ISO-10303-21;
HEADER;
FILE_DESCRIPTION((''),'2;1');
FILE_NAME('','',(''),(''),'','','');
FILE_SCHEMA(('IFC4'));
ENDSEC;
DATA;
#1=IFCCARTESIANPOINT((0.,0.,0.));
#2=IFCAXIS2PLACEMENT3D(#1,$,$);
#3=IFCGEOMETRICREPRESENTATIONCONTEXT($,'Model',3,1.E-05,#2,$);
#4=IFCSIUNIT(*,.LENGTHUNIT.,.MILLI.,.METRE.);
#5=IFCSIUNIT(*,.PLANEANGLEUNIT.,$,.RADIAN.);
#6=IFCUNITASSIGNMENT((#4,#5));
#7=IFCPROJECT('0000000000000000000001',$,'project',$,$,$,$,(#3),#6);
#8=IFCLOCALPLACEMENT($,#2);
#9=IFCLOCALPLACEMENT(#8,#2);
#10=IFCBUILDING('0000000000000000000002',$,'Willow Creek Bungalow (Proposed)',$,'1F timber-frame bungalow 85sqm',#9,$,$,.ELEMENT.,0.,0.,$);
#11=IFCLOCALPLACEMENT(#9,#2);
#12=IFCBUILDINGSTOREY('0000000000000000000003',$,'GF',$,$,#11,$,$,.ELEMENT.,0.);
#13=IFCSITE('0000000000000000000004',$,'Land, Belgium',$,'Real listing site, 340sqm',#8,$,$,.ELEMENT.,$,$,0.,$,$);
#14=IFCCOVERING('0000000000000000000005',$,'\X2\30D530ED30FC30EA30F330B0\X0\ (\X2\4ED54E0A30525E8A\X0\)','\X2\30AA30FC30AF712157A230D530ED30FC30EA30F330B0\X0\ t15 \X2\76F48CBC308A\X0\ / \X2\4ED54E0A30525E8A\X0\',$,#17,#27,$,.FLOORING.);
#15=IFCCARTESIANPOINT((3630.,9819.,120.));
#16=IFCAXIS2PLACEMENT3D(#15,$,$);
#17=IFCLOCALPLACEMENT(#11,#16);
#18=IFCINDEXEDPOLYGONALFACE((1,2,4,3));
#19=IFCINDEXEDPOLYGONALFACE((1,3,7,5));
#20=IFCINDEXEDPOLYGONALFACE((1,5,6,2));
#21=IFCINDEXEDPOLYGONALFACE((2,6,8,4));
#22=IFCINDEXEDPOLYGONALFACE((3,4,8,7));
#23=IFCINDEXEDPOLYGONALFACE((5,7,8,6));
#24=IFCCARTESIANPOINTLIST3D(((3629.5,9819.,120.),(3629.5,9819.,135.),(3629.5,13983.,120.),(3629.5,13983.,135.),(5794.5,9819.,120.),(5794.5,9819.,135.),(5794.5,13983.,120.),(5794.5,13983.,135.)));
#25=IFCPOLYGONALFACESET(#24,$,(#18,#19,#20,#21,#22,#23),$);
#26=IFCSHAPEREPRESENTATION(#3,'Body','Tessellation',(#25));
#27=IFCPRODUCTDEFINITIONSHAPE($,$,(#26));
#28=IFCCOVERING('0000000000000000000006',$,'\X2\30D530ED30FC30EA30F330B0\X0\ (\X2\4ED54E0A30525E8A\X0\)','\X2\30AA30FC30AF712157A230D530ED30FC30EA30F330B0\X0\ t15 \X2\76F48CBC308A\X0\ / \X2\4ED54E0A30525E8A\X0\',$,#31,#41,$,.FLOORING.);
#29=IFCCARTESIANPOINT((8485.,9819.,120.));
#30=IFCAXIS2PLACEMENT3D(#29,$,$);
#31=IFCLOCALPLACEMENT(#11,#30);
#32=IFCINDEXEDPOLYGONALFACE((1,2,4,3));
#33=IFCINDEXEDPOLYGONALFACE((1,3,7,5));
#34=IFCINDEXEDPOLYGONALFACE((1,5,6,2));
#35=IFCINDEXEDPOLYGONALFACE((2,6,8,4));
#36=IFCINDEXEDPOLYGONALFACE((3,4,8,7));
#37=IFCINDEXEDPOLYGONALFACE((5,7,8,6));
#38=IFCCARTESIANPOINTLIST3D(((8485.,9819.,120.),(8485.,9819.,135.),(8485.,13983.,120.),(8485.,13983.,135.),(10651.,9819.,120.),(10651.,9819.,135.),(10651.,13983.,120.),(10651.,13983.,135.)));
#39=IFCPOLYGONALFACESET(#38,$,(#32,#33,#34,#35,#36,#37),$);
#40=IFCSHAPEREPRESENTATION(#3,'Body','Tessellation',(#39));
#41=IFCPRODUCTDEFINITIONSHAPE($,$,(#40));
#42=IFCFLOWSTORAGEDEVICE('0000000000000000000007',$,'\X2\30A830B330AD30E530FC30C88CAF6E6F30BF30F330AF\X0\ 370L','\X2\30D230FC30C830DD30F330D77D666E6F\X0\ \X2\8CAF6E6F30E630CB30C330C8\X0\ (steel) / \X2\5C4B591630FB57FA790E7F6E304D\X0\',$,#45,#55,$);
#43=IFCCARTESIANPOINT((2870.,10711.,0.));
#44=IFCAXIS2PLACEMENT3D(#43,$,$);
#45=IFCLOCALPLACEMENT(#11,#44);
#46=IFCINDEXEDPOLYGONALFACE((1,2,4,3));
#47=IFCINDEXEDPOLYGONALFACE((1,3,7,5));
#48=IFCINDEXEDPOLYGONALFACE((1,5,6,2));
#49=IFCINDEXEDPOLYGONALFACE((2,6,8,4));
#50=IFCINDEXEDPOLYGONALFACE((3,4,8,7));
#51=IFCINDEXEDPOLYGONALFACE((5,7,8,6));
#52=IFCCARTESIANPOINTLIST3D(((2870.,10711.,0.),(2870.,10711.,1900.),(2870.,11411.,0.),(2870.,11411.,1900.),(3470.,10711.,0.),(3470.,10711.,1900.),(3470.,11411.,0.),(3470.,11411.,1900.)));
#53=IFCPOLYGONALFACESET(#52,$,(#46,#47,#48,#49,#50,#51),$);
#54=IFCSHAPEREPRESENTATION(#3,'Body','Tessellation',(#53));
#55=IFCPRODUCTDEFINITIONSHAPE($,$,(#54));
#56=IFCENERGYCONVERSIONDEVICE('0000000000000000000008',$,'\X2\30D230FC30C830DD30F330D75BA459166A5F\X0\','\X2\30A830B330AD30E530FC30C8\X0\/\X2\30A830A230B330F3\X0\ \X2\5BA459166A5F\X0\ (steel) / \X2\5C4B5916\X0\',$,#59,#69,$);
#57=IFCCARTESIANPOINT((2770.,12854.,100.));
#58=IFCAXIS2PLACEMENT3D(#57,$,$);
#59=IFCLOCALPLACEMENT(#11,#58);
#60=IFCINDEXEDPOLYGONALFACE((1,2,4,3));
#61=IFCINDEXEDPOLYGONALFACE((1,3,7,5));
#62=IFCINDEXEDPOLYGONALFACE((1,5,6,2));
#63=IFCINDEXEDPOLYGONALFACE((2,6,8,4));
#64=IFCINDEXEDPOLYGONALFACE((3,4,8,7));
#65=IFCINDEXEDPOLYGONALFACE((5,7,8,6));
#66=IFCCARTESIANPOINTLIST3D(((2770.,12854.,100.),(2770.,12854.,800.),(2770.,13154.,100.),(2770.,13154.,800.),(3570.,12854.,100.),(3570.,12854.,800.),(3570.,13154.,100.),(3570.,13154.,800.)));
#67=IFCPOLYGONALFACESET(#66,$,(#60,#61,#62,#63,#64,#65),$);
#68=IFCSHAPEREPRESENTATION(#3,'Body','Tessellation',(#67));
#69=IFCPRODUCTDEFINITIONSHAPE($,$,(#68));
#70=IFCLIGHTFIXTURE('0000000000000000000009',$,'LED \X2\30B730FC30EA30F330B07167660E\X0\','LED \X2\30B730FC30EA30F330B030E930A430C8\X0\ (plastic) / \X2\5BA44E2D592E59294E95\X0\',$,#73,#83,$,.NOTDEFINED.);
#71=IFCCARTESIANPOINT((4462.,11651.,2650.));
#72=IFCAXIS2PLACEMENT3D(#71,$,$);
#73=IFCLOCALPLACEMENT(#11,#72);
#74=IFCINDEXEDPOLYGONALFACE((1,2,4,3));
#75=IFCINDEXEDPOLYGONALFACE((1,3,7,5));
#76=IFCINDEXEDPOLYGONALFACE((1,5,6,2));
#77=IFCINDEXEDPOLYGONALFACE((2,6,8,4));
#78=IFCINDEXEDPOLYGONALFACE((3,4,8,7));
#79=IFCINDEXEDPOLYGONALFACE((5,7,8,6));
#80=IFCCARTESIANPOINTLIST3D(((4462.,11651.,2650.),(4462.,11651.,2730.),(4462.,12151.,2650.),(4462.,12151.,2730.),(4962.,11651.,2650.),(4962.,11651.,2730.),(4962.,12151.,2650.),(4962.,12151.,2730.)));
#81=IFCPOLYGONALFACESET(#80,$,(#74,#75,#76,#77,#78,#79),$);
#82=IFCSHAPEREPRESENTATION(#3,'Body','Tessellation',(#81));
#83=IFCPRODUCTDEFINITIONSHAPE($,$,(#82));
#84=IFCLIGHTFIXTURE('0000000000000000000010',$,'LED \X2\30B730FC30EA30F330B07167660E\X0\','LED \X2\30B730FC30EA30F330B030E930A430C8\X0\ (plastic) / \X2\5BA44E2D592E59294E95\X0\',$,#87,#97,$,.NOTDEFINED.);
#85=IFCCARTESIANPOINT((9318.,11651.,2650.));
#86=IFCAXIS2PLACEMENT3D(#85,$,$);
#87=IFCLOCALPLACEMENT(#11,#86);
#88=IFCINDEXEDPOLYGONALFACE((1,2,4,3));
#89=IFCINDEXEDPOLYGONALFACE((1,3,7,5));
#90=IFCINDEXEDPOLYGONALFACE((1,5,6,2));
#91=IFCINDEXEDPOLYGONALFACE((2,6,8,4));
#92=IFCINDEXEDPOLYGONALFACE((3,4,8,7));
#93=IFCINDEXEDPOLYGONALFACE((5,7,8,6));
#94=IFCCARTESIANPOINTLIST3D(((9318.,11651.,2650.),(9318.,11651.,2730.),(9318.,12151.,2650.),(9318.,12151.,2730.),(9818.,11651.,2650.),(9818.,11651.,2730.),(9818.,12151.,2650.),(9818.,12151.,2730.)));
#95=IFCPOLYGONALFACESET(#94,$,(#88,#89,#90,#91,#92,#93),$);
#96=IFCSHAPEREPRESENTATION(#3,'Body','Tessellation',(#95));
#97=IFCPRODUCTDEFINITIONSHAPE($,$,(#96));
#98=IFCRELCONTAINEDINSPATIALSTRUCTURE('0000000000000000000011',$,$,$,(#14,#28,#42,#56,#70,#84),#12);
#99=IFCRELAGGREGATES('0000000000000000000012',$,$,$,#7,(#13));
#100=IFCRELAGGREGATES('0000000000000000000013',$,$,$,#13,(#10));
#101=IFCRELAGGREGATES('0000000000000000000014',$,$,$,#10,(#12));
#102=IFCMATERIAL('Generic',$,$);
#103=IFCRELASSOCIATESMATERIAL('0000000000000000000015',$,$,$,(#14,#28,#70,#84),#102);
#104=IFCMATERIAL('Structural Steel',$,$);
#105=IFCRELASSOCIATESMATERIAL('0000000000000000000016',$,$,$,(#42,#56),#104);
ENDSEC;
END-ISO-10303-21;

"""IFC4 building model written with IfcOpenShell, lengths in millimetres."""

from ifc_helpers import new_model, si_unit, frame, frame_2d, origin, place, context, project, spatial, rectangle, extrude, material, element, save


model = new_model("IFC4")

# Units and contexts
model_context = context("Model", 3, precision=1e-05, world=origin())
ifc_project = project(units=[si_unit("LENGTHUNIT", "METRE", prefix="MILLI"), si_unit("PLANEANGLEUNIT", "RADIAN")], contexts=[model_context])

# Site, building, storey
site_placement = place(None, origin())
site = spatial("IfcSite", under=ifc_project, at=site_placement, Name="Land, Belgium", ObjectType="Real listing site, 340sqm", CompositionType="ELEMENT", RefElevation=0.0)
building_placement = place(site_placement, origin())
building = spatial("IfcBuilding", under=site, at=building_placement, Name="Willow Creek Bungalow (Proposed)", ObjectType="1F timber-frame bungalow 85sqm", CompositionType="ELEMENT", ElevationOfRefHeight=0.0, ElevationOfTerrain=0.0)
storey_placement = place(building_placement, origin())
storey = spatial("IfcBuildingStorey", under=building, at=storey_placement, Name="GF", CompositionType="ELEMENT", Elevation=0.0)

# Shared definitions
ifc_material_1 = material(Name="Structural Steel")

# Coverings
ifc_material_2 = material(Name="Generic")
covering_1_placement = place(storey_placement, frame((3630.0, 9819.0, 120.0)))
element("IfcCovering", 1, at=covering_1_placement, inside=storey, material=ifc_material_2, Name="フローリング (仕上げ床)", Description="オーク無垢フローリング t15 直貼り / 仕上げ床", PredefinedType="FLOORING", context=model_context, shape_type="SweptSolid", body=[
    extrude(rectangle(XDim=2165.0, YDim=4164.0, at=frame_2d((1082.0, 2082.0))), frame((3630.0, 9819.0, 120.0)), (0.0, 0.0, 1.0), 15.0),
])
covering_2_placement = place(storey_placement, frame((8485.0, 9819.0, 120.0)))
element("IfcCovering", 2, at=covering_2_placement, inside=storey, material=ifc_material_2, Name="フローリング (仕上げ床)", Description="オーク無垢フローリング t15 直貼り / 仕上げ床", PredefinedType="FLOORING", context=model_context, shape_type="SweptSolid", body=[
    extrude(rectangle(XDim=2166.0, YDim=4164.0, at=frame_2d((1083.0, 2082.0))), frame((8485.0, 9819.0, 120.0)), (0.0, 0.0, 1.0), 15.0),
])

# Flow storage device
flow_storage_device_placement = place(storey_placement, frame((2870.0, 10711.0, 0.0)))
element("IfcFlowStorageDevice", 3, at=flow_storage_device_placement, inside=storey, material=ifc_material_1, Name="エコキュート貯湯タンク 370L", Description="ヒートポンプ給湯 貯湯ユニット (steel) / 屋外・基礎置き", context=model_context, shape_type="SweptSolid", body=[
    extrude(rectangle(XDim=600.0, YDim=700.0, at=frame_2d((300.0, 350.0))), frame((2870.0, 10711.0, 0.0)), (0.0, 0.0, 1.0), 1900.0),
])

# Energy conversion device
energy_conversion_device_placement = place(storey_placement, frame((2770.0, 12854.0, 100.0)))
element("IfcEnergyConversionDevice", 4, at=energy_conversion_device_placement, inside=storey, material=ifc_material_1, Name="ヒートポンプ室外機", Description="エコキュート/エアコン 室外機 (steel) / 屋外", context=model_context, shape_type="SweptSolid", body=[
    extrude(rectangle(XDim=800.0, YDim=300.0, at=frame_2d((400.0, 150.0))), frame((2770.0, 12854.0, 100.0)), (0.0, 0.0, 1.0), 700.0),
])

# Light fixtures
light_fixture_1_placement = place(storey_placement, frame((4462.0, 11651.0, 2650.0)))
element("IfcLightFixture", 5, at=light_fixture_1_placement, inside=storey, material=ifc_material_2, Name="LED シーリング照明", Description="LED シーリングライト (plastic) / 室中央天井", PredefinedType="NOTDEFINED", context=model_context, shape_type="SweptSolid", body=[
    extrude(rectangle(XDim=500.0, YDim=500.0, at=frame_2d((250.0, 250.0))), frame((4462.0, 11651.0, 2650.0)), (0.0, 0.0, 1.0), 80.0),
])
light_fixture_2_placement = place(storey_placement, frame((9318.0, 11651.0, 2650.0)))
element("IfcLightFixture", 6, at=light_fixture_2_placement, inside=storey, material=ifc_material_2, Name="LED シーリング照明", Description="LED シーリングライト (plastic) / 室中央天井", PredefinedType="NOTDEFINED", context=model_context, shape_type="SweptSolid", body=[
    extrude(rectangle(XDim=500.0, YDim=500.0, at=frame_2d((250.0, 250.0))), frame((9318.0, 11651.0, 2650.0)), (0.0, 0.0, 1.0), 80.0),
])

save(model, "model.ifc")
